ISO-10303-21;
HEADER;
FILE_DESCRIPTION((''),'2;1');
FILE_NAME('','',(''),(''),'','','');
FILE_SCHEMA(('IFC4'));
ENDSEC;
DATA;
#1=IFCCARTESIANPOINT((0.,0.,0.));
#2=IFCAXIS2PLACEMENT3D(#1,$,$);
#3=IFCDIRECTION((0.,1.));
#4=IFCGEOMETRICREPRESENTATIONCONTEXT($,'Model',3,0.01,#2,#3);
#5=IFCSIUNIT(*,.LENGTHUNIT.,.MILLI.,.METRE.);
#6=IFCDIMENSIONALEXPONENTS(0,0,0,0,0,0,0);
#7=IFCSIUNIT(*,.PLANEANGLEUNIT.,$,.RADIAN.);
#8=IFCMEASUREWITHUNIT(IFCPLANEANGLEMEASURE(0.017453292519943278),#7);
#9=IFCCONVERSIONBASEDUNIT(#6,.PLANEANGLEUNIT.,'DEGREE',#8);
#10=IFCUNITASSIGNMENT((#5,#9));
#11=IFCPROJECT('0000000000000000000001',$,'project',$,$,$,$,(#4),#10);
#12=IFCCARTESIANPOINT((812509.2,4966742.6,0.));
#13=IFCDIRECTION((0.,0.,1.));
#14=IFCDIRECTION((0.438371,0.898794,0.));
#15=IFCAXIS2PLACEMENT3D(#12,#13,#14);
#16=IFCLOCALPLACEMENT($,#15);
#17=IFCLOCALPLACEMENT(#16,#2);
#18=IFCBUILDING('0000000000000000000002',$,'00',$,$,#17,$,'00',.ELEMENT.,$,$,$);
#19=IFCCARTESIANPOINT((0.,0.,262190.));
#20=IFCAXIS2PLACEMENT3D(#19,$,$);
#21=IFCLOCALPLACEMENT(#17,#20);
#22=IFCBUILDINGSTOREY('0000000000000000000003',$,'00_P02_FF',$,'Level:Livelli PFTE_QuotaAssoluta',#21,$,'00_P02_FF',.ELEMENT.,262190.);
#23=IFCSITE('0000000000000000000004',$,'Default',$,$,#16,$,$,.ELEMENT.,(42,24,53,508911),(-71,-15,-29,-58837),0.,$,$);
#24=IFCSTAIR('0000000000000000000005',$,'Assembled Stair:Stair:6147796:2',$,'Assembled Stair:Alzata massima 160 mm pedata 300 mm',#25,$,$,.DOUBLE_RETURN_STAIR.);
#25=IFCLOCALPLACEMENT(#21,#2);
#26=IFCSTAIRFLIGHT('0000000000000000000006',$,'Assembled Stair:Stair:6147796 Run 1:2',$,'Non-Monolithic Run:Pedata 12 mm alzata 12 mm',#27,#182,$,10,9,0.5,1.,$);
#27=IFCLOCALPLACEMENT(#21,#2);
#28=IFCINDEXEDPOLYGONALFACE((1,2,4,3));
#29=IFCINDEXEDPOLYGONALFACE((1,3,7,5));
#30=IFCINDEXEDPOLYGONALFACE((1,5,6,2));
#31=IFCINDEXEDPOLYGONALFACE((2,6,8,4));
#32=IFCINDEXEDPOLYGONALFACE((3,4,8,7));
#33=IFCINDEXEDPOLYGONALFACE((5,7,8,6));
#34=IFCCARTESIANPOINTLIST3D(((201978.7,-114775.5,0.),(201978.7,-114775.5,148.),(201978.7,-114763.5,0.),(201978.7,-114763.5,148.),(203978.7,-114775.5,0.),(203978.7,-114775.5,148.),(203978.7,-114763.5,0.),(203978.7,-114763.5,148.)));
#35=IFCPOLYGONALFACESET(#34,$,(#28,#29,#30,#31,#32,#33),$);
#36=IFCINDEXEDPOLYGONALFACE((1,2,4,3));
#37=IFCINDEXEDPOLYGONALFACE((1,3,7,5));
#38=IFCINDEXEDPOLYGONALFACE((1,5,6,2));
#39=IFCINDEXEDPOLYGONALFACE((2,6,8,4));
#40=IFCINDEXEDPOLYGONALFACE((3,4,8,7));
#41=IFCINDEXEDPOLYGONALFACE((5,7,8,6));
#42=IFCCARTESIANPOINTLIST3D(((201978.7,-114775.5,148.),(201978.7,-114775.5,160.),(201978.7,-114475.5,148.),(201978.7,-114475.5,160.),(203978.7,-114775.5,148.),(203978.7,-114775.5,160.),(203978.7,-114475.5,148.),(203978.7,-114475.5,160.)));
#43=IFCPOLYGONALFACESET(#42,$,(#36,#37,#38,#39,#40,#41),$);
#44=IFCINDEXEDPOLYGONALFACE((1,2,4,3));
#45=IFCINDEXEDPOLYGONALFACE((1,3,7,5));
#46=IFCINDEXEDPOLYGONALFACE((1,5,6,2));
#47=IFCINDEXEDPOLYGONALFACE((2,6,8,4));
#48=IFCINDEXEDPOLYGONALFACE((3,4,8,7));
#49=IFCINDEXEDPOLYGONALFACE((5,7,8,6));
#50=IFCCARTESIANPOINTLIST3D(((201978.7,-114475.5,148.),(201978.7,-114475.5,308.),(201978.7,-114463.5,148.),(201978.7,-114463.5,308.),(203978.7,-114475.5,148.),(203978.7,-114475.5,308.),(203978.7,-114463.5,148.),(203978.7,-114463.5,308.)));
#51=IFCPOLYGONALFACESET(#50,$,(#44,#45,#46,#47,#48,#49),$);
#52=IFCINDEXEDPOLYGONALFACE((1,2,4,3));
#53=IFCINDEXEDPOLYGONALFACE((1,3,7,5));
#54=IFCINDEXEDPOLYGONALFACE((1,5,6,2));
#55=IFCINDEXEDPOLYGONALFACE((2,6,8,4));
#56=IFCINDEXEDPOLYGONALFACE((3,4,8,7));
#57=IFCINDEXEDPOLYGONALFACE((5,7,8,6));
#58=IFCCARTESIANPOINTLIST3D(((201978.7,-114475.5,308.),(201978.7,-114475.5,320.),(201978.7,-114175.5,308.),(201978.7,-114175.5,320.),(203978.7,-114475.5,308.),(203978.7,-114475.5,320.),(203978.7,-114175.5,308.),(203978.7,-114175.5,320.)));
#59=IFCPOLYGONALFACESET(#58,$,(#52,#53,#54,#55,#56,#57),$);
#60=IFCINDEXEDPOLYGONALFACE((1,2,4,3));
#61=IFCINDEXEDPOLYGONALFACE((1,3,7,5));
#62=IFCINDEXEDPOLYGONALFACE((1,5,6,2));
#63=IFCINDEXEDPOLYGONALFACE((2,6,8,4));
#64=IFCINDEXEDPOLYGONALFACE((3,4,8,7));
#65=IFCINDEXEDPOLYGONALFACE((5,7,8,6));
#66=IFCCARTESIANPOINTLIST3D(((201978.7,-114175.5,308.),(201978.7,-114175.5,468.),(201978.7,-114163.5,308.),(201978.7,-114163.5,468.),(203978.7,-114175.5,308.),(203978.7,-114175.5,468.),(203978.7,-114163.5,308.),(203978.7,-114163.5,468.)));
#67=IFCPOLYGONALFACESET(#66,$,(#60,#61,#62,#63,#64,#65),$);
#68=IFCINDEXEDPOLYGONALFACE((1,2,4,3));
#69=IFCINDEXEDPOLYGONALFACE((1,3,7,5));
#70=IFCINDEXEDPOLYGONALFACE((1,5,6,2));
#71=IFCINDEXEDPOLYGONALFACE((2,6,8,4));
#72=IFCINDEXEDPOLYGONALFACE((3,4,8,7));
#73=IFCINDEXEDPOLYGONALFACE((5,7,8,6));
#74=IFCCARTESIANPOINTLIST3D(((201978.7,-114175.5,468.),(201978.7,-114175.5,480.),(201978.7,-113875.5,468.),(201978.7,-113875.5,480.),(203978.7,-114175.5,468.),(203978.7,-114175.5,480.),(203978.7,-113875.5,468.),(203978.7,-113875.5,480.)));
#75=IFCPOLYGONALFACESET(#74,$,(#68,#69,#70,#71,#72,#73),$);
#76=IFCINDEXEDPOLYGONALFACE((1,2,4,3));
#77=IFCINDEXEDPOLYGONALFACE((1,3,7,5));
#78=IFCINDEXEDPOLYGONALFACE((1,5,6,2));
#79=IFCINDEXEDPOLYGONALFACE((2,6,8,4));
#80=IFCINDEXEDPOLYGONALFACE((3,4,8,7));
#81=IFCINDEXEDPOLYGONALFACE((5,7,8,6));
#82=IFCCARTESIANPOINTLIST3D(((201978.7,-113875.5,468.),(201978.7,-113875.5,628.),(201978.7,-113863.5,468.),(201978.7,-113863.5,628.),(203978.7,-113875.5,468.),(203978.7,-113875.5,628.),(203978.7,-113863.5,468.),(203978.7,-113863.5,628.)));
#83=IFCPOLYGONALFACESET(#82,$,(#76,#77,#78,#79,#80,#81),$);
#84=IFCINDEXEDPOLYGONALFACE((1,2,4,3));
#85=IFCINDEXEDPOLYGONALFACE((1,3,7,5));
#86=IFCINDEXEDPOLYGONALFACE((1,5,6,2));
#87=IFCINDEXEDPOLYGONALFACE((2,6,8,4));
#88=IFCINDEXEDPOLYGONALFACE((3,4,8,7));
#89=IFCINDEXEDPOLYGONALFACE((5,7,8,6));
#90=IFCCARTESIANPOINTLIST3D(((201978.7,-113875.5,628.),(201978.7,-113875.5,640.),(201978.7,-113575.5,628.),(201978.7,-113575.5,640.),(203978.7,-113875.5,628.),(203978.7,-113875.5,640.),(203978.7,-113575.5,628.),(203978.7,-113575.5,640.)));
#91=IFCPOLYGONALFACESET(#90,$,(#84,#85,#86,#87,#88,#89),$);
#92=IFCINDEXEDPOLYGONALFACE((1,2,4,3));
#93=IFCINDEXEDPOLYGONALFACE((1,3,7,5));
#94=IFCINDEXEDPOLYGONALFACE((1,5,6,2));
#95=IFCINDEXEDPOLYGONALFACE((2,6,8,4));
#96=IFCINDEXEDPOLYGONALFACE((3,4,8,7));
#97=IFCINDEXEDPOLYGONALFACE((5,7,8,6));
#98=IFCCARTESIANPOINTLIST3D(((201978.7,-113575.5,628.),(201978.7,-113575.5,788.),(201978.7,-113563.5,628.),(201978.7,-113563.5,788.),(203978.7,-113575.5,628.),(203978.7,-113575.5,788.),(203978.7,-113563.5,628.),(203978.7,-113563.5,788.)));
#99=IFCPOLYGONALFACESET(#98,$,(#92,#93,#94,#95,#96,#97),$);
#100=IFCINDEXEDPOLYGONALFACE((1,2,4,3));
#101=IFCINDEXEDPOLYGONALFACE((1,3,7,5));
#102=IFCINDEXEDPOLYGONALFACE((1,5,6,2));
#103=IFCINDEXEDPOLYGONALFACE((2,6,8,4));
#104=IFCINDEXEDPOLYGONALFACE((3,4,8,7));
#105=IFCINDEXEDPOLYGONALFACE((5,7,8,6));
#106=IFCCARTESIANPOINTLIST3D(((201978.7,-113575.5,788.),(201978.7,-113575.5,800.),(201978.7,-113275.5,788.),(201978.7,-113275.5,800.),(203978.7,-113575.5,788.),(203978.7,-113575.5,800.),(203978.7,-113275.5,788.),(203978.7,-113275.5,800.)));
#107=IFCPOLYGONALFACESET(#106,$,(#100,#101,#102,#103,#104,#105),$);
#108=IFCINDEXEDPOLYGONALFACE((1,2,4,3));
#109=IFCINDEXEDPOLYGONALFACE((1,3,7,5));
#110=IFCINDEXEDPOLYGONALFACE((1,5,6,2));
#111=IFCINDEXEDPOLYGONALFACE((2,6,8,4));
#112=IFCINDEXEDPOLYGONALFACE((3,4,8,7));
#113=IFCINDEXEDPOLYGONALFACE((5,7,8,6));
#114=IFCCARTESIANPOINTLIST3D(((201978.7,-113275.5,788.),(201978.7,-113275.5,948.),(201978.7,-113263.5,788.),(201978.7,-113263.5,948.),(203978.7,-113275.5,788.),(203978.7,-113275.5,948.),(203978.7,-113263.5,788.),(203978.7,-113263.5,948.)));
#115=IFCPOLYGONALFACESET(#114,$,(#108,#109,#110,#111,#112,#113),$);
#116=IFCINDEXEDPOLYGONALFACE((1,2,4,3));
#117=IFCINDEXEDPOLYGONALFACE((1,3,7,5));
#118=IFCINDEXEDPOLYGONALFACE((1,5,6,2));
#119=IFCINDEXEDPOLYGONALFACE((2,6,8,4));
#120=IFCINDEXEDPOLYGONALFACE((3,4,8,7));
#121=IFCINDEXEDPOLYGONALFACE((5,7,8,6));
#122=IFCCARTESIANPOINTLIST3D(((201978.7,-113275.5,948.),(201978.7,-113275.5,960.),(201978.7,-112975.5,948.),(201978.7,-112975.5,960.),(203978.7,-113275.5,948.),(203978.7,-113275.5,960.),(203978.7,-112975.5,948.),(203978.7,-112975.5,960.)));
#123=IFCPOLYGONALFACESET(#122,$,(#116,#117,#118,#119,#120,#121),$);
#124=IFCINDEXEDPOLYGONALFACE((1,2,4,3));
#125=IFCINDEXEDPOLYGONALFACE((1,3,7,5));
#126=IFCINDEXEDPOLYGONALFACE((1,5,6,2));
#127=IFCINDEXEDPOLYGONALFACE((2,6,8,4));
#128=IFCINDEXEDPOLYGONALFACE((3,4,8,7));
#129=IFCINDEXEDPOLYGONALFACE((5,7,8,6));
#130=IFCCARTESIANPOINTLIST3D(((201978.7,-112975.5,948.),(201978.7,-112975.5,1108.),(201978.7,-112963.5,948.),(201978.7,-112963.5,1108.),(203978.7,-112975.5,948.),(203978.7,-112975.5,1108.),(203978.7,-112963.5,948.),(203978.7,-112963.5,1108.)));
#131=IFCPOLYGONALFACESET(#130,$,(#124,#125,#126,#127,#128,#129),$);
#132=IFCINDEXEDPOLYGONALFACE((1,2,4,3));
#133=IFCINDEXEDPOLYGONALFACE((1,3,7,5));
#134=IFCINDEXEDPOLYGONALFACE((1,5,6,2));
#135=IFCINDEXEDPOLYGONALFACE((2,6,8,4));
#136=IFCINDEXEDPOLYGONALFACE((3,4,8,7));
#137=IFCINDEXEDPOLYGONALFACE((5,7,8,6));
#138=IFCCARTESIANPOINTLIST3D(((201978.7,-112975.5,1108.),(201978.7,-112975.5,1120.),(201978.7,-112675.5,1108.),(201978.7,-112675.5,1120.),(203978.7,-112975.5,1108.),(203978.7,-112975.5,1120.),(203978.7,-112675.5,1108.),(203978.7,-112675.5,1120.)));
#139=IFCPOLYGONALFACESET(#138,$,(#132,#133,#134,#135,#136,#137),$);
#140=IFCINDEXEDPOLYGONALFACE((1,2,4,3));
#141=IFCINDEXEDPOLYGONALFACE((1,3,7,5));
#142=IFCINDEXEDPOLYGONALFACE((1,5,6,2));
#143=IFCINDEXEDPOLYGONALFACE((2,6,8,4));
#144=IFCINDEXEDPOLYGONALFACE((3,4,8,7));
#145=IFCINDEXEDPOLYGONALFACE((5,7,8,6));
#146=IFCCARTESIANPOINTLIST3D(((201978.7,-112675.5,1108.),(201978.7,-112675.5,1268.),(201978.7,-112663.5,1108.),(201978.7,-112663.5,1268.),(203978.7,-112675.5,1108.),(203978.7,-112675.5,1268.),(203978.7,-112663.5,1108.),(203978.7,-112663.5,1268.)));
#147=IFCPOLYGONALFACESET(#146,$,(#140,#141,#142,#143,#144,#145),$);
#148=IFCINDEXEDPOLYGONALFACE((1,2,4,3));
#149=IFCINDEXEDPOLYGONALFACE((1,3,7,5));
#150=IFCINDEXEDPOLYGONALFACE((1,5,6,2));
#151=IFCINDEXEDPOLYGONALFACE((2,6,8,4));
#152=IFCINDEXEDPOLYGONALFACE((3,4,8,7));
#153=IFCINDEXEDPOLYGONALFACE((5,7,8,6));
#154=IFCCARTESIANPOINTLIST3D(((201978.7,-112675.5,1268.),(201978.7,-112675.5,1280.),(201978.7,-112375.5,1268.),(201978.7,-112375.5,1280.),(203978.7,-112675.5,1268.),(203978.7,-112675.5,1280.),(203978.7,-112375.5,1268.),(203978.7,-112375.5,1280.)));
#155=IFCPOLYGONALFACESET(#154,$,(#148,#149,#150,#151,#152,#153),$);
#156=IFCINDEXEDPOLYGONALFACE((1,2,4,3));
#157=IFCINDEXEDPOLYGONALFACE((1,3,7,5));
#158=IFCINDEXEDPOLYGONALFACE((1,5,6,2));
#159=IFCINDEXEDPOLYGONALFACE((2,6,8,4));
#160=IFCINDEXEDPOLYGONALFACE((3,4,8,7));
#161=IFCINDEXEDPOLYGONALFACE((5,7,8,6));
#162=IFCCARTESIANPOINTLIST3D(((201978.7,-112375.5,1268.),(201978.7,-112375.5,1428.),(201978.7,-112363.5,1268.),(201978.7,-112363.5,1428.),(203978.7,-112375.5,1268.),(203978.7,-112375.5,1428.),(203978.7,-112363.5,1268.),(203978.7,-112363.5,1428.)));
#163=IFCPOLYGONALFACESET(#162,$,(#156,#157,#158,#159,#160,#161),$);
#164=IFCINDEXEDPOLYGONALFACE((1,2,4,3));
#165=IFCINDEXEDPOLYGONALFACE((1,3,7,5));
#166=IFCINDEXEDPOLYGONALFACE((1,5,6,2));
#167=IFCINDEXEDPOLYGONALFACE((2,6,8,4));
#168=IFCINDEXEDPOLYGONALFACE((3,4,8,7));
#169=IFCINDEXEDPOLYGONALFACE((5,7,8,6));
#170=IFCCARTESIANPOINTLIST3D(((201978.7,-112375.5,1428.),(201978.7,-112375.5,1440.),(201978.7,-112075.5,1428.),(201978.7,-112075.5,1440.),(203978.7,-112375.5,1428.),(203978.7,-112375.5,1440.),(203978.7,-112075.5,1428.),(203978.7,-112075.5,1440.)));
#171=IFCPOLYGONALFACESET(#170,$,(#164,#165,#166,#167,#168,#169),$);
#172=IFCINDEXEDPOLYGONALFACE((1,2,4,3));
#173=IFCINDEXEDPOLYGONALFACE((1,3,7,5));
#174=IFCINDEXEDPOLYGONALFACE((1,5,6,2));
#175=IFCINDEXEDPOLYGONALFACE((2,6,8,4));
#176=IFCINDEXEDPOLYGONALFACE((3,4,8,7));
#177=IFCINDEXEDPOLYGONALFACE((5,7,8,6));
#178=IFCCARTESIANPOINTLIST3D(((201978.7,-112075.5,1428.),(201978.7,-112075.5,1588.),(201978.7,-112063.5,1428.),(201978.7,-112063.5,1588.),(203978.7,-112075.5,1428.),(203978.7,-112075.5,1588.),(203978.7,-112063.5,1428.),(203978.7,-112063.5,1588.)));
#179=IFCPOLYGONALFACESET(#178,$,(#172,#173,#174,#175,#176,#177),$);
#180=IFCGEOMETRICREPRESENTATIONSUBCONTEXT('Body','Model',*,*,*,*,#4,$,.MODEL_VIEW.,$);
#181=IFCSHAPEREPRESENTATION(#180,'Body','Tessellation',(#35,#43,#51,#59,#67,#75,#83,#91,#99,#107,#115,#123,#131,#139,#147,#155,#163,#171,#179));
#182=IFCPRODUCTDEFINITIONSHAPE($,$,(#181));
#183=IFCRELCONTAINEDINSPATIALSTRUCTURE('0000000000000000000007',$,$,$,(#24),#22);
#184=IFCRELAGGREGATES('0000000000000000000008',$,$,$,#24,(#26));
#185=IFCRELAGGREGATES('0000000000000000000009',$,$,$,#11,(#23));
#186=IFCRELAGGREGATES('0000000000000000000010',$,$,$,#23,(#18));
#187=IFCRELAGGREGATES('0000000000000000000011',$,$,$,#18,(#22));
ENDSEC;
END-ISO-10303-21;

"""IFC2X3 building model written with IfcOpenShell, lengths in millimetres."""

from ifc_helpers import new_model, entity, si_unit, converted_unit, direction, frame, frame_2d, origin, origin_2d_with_axis, place, context, subcontext, project, spatial, rectangle, extrude, element, aggregate, save


model = new_model("IFC2X3")

# Units and contexts
model_context = context("Model", 3, precision=0.01, world=origin(), true_north=direction((0.0, 1.0)))
body_context = subcontext(model_context, "Body", "Model", "MODEL_VIEW")
ifc_project = project(units=[si_unit("LENGTHUNIT", "METRE", prefix="MILLI"), converted_unit("PLANEANGLEUNIT", "DEGREE", entity("IfcPlaneAngleMeasure", 0.017453292519943278), si_unit("PLANEANGLEUNIT", "RADIAN"), dimensions=[0, 0, 0, 0, 0, 0, 0])], contexts=[model_context])

# Site, building, storey
site_placement = place(None, frame((812509.2, 4966742.6, 0.0), z_axis=(0.0, 0.0, 1.0), x_axis=(0.438371, 0.898794, 0.0)))
site = spatial("IfcSite", under=ifc_project, at=site_placement, Name="Default", CompositionType="ELEMENT", RefLatitude=(42, 24, 53, 508911), RefLongitude=(-71, -15, -29, -58837), RefElevation=0.0)
building_placement = place(site_placement, origin())
building = spatial("IfcBuilding", under=site, at=building_placement, Name="00", LongName="00", CompositionType="ELEMENT")
storey_placement = place(building_placement, frame((0.0, 0.0, 262190.0)))
storey = spatial("IfcBuildingStorey", under=building, at=storey_placement, Name="00_P02_FF", ObjectType="Level:Livelli PFTE_QuotaAssoluta", LongName="00_P02_FF", CompositionType="ELEMENT", Elevation=262190.0)

# Stair
stair_1_placement = place(storey_placement, origin())
stair_1 = element("IfcStair", 1, at=stair_1_placement, inside=storey, Name="Assembled Stair:Stair:6147796:2", ObjectType="Assembled Stair:Alzata massima 160 mm pedata 300 mm", ShapeType="DOUBLE_RETURN_STAIR")

# Stair flight
stair_flight_1_placement = place(stair_1_placement, origin())
stair_flight_1 = element("IfcStairFlight", 2, at=stair_flight_1_placement, Name="Assembled Stair:Stair:6147796 Run 1:2", ObjectType="Non-Monolithic Run:Pedata 12 mm alzata 12 mm", NumberOfRiser=10, NumberOfTreads=9, RiserHeight=0.5, TreadLength=1.0, context=body_context, shape_type="SweptSolid", body=[
    extrude(rectangle(XDim=2000.0, YDim=12.0, at=origin_2d_with_axis()), frame((202978.7, -114769.5, 0.0), z_axis=(0.0, 0.0, 1.0), x_axis=(-1.0, 0.0, 0.0)), (0.0, 0.0, 1.0), 148.0),
    extrude(rectangle(XDim=300.0, YDim=2000.0, at=frame_2d((0.0, 0.0), x_axis=(1.0, 0.0))), frame((202978.7, -114625.5, 148.0), z_axis=(0.0, 0.0, 1.0), x_axis=(0.0, -1.0, 0.0)), (0.0, 0.0, 1.0), 12.0),
    extrude(rectangle(XDim=2000.0, YDim=12.0, at=frame_2d((0.0, 0.0), x_axis=(1.0, 0.0))), frame((202978.7, -114469.5, 148.0), z_axis=(0.0, 0.0, 1.0), x_axis=(-1.0, 0.0, 0.0)), (0.0, 0.0, 1.0), 160.0),
    extrude(rectangle(XDim=300.0, YDim=2000.0, at=frame_2d((0.0, 0.0), x_axis=(1.0, 0.0))), frame((202978.7, -114325.5, 308.0), z_axis=(0.0, 0.0, 1.0), x_axis=(0.0, -1.0, 0.0)), (0.0, 0.0, 1.0), 12.0),
    extrude(rectangle(XDim=2000.0, YDim=12.0, at=frame_2d((0.0, 0.0), x_axis=(1.0, 0.0))), frame((202978.7, -114169.5, 308.0), z_axis=(0.0, 0.0, 1.0), x_axis=(-1.0, 0.0, 0.0)), (0.0, 0.0, 1.0), 160.0),
    extrude(rectangle(XDim=300.0, YDim=2000.0, at=frame_2d((0.0, 0.0), x_axis=(1.0, 0.0))), frame((202978.7, -114025.5, 468.0), z_axis=(0.0, 0.0, 1.0), x_axis=(0.0, -1.0, 0.0)), (0.0, 0.0, 1.0), 12.0),
    extrude(rectangle(XDim=2000.0, YDim=12.0, at=frame_2d((0.0, 0.0), x_axis=(1.0, 0.0))), frame((202978.7, -113869.5, 468.0), z_axis=(0.0, 0.0, 1.0), x_axis=(-1.0, 0.0, 0.0)), (0.0, 0.0, 1.0), 160.0),
    extrude(rectangle(XDim=300.0, YDim=2000.0, at=frame_2d((0.0, 0.0), x_axis=(1.0, 0.0))), frame((202978.7, -113725.5, 628.0), z_axis=(0.0, 0.0, 1.0), x_axis=(0.0, -1.0, 0.0)), (0.0, 0.0, 1.0), 12.0),
    extrude(rectangle(XDim=2000.0, YDim=12.0, at=frame_2d((0.0, 0.0), x_axis=(1.0, 0.0))), frame((202978.7, -113569.5, 628.0), z_axis=(0.0, 0.0, 1.0), x_axis=(-1.0, 0.0, 0.0)), (0.0, 0.0, 1.0), 160.0),
    extrude(rectangle(XDim=300.0, YDim=2000.0, at=frame_2d((0.0, 0.0), x_axis=(1.0, 0.0))), frame((202978.7, -113425.5, 788.0), z_axis=(0.0, 0.0, 1.0), x_axis=(0.0, -1.0, 0.0)), (0.0, 0.0, 1.0), 12.0),
    extrude(rectangle(XDim=2000.0, YDim=12.0, at=frame_2d((0.0, 0.0), x_axis=(1.0, 0.0))), frame((202978.7, -113269.5, 788.0), z_axis=(0.0, 0.0, 1.0), x_axis=(-1.0, 0.0, 0.0)), (0.0, 0.0, 1.0), 160.0),
    extrude(rectangle(XDim=300.0, YDim=2000.0, at=frame_2d((0.0, 0.0), x_axis=(1.0, 0.0))), frame((202978.7, -113125.5, 948.0), z_axis=(0.0, 0.0, 1.0), x_axis=(0.0, -1.0, 0.0)), (0.0, 0.0, 1.0), 12.0),
    extrude(rectangle(XDim=2000.0, YDim=12.0, at=frame_2d((0.0, 0.0), x_axis=(1.0, 0.0))), frame((202978.7, -112969.5, 948.0), z_axis=(0.0, 0.0, 1.0), x_axis=(-1.0, 0.0, 0.0)), (0.0, 0.0, 1.0), 160.0),
    extrude(rectangle(XDim=300.0, YDim=2000.0, at=frame_2d((0.0, 0.0), x_axis=(1.0, 0.0))), frame((202978.7, -112825.5, 1108.0), z_axis=(0.0, 0.0, 1.0), x_axis=(0.0, -1.0, 0.0)), (0.0, 0.0, 1.0), 12.0),
    extrude(rectangle(XDim=2000.0, YDim=12.0, at=frame_2d((0.0, 0.0), x_axis=(1.0, 0.0))), frame((202978.7, -112669.5, 1108.0), z_axis=(0.0, 0.0, 1.0), x_axis=(-1.0, 0.0, 0.0)), (0.0, 0.0, 1.0), 160.0),
    extrude(rectangle(XDim=300.0, YDim=2000.0, at=frame_2d((0.0, 0.0), x_axis=(1.0, 0.0))), frame((202978.7, -112525.5, 1268.0), z_axis=(0.0, 0.0, 1.0), x_axis=(0.0, -1.0, 0.0)), (0.0, 0.0, 1.0), 12.0),
    extrude(rectangle(XDim=2000.0, YDim=12.0, at=frame_2d((0.0, 0.0), x_axis=(1.0, 0.0))), frame((202978.7, -112369.5, 1268.0), z_axis=(0.0, 0.0, 1.0), x_axis=(-1.0, 0.0, 0.0)), (0.0, 0.0, 1.0), 160.0),
    extrude(rectangle(XDim=300.0, YDim=2000.0, at=frame_2d((0.0, 0.0), x_axis=(1.0, 0.0))), frame((202978.7, -112225.5, 1428.0), z_axis=(0.0, 0.0, 1.0), x_axis=(0.0, -1.0, 0.0)), (0.0, 0.0, 1.0), 12.0),
    extrude(rectangle(XDim=2000.0, YDim=12.0, at=origin_2d_with_axis()), frame((202978.7, -112069.5, 1428.0), z_axis=(0.0, 0.0, 1.0), x_axis=(-1.0, 0.0, 0.0)), (0.0, 0.0, 1.0), 160.0),
])
aggregate(stair_1, [stair_flight_1])

save(model, "model.ifc")
